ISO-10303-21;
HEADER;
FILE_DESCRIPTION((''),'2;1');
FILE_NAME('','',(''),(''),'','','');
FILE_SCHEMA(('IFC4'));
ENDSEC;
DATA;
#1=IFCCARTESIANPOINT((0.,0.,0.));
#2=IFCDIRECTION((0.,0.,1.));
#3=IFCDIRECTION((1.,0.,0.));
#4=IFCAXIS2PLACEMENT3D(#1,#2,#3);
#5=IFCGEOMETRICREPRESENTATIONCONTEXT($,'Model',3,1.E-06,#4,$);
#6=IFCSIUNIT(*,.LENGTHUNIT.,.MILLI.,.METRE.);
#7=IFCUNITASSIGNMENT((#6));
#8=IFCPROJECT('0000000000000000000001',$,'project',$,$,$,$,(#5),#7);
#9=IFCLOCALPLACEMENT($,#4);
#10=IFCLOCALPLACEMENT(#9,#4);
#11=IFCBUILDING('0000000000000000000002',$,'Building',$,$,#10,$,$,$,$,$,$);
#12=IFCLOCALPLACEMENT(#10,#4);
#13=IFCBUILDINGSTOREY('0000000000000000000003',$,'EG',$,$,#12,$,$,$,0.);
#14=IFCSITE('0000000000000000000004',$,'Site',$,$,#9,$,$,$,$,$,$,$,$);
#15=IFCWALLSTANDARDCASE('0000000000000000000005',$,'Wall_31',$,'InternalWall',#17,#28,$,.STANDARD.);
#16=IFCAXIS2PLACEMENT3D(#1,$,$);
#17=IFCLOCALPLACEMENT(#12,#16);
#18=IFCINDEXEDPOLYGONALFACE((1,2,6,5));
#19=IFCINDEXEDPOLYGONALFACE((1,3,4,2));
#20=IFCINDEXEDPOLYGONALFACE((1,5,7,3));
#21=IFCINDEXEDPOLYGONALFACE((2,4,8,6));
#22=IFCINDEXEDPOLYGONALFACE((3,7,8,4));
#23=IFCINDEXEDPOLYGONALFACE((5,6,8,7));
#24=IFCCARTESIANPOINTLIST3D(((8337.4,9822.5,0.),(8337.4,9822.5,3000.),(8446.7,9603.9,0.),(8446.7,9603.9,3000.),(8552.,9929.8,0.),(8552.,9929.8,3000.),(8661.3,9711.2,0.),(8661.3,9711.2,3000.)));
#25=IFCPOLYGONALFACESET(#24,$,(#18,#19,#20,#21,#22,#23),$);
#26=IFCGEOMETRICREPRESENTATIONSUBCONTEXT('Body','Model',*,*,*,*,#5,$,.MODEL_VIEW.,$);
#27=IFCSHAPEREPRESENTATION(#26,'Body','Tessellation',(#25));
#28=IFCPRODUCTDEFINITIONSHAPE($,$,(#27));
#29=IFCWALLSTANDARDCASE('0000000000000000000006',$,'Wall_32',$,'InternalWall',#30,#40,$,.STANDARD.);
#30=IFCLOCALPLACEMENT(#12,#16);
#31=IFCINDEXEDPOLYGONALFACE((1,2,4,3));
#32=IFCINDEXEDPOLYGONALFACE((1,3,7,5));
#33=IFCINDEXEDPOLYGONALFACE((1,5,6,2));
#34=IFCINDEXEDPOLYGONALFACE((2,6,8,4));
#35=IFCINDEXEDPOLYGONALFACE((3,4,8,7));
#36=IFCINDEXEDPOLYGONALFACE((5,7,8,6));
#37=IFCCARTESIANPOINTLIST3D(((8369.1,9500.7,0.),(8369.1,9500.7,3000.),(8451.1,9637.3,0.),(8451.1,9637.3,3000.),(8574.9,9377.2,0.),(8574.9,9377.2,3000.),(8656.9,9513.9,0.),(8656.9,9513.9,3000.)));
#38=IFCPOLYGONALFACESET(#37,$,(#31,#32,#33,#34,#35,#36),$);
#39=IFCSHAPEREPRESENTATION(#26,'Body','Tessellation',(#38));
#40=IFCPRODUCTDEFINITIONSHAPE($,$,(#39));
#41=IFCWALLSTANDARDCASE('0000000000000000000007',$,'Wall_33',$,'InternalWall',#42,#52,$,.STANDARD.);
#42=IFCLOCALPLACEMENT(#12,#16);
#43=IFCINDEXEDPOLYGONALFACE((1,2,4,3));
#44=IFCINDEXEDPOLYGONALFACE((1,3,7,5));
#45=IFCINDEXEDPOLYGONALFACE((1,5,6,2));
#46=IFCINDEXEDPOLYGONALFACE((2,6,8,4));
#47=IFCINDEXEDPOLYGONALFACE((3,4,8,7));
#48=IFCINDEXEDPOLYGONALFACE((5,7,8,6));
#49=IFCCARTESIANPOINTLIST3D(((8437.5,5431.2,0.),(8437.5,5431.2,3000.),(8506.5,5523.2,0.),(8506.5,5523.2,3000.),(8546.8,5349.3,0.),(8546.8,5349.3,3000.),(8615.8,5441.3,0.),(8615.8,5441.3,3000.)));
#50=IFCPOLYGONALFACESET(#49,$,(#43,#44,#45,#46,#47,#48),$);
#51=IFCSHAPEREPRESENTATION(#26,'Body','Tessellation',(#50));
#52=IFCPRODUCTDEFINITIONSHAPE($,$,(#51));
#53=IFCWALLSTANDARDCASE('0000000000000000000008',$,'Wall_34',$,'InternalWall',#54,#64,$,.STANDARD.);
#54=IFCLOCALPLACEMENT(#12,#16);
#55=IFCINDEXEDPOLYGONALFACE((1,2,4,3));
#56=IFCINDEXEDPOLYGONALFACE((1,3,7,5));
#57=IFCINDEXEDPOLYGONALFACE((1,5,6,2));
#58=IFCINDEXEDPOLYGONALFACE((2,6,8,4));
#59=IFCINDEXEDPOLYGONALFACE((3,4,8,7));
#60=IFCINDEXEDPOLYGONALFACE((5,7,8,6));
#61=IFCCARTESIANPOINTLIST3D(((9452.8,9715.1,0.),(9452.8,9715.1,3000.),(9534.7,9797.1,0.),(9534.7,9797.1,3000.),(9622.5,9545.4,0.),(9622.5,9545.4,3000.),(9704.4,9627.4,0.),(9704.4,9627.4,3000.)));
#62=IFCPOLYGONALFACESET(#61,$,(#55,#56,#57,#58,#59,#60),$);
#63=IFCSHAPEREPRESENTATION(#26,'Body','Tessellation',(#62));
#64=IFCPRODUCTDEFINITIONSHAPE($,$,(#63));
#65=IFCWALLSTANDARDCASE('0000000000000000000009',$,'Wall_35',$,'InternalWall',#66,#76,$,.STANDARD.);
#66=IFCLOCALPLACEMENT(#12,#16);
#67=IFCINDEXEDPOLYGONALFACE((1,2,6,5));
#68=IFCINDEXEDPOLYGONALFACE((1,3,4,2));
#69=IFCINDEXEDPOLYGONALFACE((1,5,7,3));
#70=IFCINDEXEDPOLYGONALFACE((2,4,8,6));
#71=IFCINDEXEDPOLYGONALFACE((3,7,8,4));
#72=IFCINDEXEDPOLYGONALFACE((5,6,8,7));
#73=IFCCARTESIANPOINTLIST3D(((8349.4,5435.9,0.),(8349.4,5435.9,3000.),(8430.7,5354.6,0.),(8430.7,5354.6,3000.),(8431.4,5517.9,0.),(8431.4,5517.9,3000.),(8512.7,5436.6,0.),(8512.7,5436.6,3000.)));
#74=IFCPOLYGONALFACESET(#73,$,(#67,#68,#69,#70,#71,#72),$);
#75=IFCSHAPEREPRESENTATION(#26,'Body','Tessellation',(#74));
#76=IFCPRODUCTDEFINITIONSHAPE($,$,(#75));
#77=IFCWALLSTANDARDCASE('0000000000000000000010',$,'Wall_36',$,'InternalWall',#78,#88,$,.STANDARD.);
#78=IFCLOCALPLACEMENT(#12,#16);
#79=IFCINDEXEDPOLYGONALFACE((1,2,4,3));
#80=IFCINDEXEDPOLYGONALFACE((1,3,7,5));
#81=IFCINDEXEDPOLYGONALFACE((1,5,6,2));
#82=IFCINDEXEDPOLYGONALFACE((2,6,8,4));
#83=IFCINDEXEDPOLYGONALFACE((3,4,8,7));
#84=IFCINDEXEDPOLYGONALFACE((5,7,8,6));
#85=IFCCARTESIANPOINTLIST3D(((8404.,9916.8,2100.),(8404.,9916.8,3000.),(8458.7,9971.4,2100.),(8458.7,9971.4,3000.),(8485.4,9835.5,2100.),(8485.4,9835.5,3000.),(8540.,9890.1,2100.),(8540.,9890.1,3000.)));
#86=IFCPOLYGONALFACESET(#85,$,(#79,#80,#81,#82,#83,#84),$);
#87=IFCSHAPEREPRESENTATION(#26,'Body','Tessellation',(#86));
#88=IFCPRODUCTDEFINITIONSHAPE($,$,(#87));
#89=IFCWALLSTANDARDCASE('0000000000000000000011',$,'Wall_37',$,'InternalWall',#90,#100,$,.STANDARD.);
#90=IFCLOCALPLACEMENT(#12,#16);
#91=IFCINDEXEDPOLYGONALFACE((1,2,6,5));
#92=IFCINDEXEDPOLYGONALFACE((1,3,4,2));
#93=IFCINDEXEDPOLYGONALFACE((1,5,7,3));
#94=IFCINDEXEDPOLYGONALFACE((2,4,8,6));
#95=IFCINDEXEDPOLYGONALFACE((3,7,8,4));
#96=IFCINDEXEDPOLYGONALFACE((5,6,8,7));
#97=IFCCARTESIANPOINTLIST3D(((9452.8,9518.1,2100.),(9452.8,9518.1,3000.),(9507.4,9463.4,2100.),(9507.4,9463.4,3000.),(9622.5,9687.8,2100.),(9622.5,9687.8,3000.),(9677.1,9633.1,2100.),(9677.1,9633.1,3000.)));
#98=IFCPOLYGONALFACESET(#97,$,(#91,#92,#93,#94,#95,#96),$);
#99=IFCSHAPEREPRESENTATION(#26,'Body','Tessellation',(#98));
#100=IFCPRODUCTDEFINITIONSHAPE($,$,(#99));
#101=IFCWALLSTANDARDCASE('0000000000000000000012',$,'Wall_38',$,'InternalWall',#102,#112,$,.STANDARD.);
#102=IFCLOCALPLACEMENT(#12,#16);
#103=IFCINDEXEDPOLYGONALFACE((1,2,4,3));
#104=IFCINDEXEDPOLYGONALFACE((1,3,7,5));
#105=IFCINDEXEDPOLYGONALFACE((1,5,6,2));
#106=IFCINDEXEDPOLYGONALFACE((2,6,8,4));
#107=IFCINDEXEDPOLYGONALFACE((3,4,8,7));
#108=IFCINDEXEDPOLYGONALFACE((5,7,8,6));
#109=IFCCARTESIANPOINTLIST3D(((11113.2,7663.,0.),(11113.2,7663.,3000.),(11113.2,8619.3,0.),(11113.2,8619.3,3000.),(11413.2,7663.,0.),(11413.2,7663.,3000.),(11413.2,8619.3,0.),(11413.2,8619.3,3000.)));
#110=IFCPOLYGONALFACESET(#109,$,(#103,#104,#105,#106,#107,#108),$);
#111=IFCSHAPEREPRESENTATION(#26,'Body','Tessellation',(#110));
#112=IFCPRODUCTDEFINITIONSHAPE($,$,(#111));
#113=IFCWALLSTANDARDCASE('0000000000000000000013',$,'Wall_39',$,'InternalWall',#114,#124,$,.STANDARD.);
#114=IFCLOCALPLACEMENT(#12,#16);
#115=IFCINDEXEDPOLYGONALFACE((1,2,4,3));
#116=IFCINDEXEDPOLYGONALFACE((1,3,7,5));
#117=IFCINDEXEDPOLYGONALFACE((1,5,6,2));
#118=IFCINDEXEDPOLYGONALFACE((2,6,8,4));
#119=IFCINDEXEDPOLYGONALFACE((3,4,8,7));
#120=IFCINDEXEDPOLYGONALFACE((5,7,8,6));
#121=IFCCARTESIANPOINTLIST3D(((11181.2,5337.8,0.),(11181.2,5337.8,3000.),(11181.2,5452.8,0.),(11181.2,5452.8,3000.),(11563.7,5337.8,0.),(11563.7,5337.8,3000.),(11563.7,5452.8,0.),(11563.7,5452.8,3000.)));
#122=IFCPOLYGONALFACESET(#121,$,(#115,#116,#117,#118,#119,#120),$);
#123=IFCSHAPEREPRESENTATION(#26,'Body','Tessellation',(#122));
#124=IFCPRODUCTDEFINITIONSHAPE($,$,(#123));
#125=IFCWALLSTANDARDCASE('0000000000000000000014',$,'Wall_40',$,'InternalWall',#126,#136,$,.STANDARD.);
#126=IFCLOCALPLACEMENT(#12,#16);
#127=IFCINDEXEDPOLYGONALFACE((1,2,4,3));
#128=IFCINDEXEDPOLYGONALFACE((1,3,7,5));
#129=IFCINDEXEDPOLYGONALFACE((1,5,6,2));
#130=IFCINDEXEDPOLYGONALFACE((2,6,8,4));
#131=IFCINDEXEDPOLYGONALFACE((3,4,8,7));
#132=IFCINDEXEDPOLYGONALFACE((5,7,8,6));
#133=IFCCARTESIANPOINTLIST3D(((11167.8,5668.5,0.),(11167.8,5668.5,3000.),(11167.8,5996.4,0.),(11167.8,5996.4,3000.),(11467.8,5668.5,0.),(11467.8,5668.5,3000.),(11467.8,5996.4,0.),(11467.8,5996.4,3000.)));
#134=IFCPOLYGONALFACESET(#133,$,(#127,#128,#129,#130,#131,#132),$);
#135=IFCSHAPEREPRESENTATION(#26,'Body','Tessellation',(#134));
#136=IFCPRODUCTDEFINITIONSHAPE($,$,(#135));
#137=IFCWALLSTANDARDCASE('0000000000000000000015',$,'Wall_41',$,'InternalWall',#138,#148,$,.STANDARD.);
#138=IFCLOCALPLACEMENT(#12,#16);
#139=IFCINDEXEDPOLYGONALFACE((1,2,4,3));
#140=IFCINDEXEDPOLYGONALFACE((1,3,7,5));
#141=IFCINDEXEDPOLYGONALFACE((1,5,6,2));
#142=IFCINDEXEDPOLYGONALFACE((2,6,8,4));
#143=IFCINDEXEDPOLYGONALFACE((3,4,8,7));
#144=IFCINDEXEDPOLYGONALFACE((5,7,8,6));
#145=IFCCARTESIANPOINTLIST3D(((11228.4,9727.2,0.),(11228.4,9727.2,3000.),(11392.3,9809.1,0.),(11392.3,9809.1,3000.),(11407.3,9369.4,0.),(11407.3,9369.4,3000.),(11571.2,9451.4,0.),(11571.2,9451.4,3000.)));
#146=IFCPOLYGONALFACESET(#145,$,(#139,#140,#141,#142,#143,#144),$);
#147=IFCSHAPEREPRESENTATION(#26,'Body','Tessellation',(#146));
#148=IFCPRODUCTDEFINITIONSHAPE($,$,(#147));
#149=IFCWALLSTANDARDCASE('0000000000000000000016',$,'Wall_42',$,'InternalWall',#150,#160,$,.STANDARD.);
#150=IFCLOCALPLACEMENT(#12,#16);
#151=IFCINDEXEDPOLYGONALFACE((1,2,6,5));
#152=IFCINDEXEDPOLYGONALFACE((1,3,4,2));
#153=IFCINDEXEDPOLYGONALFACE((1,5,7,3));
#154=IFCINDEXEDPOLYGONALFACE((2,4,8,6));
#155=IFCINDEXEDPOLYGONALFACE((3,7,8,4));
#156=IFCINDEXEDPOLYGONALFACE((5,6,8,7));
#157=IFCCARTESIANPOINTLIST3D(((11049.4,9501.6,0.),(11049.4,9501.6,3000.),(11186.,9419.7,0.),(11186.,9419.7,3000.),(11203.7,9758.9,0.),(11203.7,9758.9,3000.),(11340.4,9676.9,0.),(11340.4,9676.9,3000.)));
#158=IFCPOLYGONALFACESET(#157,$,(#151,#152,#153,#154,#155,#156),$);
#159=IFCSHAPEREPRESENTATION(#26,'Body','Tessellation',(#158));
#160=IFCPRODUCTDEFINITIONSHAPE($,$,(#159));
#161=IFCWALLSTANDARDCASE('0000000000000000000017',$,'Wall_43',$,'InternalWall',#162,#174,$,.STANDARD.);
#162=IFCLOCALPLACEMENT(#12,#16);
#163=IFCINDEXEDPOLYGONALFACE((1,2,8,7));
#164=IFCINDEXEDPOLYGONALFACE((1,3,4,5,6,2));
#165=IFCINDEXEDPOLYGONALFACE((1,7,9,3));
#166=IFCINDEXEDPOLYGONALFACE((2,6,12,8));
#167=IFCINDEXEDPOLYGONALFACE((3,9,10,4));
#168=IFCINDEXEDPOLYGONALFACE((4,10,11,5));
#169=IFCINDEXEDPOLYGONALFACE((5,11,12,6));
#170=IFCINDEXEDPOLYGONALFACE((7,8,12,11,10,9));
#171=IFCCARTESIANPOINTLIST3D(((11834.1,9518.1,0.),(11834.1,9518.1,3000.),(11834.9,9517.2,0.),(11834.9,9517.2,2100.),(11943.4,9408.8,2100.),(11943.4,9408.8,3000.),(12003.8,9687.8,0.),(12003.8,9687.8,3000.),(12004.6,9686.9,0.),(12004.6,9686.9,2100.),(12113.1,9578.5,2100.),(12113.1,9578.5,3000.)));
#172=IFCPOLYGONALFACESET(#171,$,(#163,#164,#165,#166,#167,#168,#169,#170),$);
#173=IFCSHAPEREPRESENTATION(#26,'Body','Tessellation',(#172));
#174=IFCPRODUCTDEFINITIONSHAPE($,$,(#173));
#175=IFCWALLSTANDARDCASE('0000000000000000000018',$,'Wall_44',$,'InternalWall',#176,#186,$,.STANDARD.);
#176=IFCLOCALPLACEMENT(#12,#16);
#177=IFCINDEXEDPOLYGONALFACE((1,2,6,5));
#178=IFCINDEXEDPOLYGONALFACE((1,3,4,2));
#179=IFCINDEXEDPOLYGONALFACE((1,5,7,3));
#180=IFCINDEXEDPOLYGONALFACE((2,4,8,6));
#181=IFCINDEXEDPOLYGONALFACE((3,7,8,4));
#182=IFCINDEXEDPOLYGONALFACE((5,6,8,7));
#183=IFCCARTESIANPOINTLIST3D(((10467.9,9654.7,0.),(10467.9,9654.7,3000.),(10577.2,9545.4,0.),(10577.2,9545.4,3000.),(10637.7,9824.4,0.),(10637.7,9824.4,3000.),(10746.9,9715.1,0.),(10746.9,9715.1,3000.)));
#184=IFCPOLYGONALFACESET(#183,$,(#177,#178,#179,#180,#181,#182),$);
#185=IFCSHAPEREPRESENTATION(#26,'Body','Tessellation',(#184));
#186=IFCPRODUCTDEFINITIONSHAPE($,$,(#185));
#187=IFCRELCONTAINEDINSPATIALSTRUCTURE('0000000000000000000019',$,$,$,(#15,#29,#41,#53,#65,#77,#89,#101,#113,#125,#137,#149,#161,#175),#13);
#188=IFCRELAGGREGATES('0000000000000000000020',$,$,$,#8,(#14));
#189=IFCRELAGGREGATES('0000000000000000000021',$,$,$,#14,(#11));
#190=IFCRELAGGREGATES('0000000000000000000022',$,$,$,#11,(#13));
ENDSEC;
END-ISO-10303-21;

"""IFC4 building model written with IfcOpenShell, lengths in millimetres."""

from ifc_helpers import new_model, si_unit, frame, origin_with_axes, place, context, subcontext, project, spatial, rectangle, extrude, element, save


model = new_model("IFC4")

# Units and contexts
model_context = context("Model", 3, precision=1e-06, world=origin_with_axes())
body_context = subcontext(model_context, "Body", "Model", "MODEL_VIEW")
ifc_project = project(units=[si_unit("LENGTHUNIT", "METRE", prefix="MILLI")], contexts=[model_context])

# Site, building, storey
site_placement = place(None, origin_with_axes())
site = spatial("IfcSite", under=ifc_project, at=site_placement, Name="Site")
building_placement = place(site_placement, origin_with_axes())
building = spatial("IfcBuilding", under=site, at=building_placement, Name="Building")
storey_placement = place(building_placement, origin_with_axes())
storey = spatial("IfcBuildingStorey", under=building, at=storey_placement, Name="EG", Elevation=0.0)

# Walls
wall_1_placement = place(storey_placement, origin_with_axes())
element("IfcWallStandardCase", 1, at=wall_1_placement, inside=storey, Name="Wall_31", ObjectType="InternalWall", PredefinedType="STANDARD", context=body_context, shape_type="SweptSolid", body=[
    extrude(rectangle(XDim=244.4, YDim=240.0), frame((8499.4, 9766.9, 0.0), z_axis=(0.0, 0.0, 1.0), x_axis=(-0.447214, 0.894427, 0.0)), (0.0, 0.0, 1.0), 3000.0),
])
wall_2_placement = place(storey_placement, origin_with_axes())
element("IfcWallStandardCase", 2, at=wall_2_placement, inside=storey, Name="Wall_32", ObjectType="InternalWall", PredefinedType="STANDARD", context=body_context, shape_type="SweptSolid", body=[
    extrude(rectangle(XDim=159.3, YDim=240.0), frame((8513.0, 9507.3, 0.0), z_axis=(0.0, 0.0, 1.0), x_axis=(0.514496, 0.857493, 0.0)), (0.0, 0.0, 1.0), 3000.0),
])
wall_3_placement = place(storey_placement, origin_with_axes())
element("IfcWallStandardCase", 3, at=wall_3_placement, inside=storey, Name="Wall_33", ObjectType="InternalWall", PredefinedType="STANDARD", context=body_context, shape_type="SweptSolid", body=[
    extrude(rectangle(XDim=136.6, YDim=115.0), frame((8526.7, 5436.3, 0.0), z_axis=(0.0, 0.0, 1.0), x_axis=(0.8, -0.6, 0.0)), (0.0, 0.0, 1.0), 3000.0),
])
wall_4_placement = place(storey_placement, origin_with_axes())
element("IfcWallStandardCase", 4, at=wall_4_placement, inside=storey, Name="Wall_34", ObjectType="InternalWall", PredefinedType="STANDARD", context=body_context, shape_type="SweptSolid", body=[
    extrude(rectangle(XDim=115.9, YDim=240.0), frame((9578.6, 9671.2, 0.0), z_axis=(0.0, 0.0, 1.0), x_axis=(0.707107, 0.707107, 0.0)), (0.0, 0.0, 1.0), 3000.0),
])
wall_5_placement = place(storey_placement, origin_with_axes())
element("IfcWallStandardCase", 5, at=wall_5_placement, inside=storey, Name="Wall_35", ObjectType="InternalWall", PredefinedType="STANDARD", context=body_context, shape_type="SweptSolid", body=[
    extrude(rectangle(XDim=115.9, YDim=115.0), frame((8431.0, 5436.3, 0.0), z_axis=(0.0, 0.0, 1.0), x_axis=(-0.707107, -0.707107, 0.0)), (0.0, 0.0, 1.0), 3000.0),
])

# Walls, openings
wall_6_placement = place(storey_placement, origin_with_axes())
wall_6 = element("IfcWallStandardCase", 6, at=wall_6_placement, inside=storey, Name="Wall_36", ObjectType="InternalWall", PredefinedType="STANDARD", context=body_context, shape_type="SweptSolid", body=[
    extrude(rectangle(XDim=77.3, YDim=115.0), frame((8472.0, 9903.5, 0.0), z_axis=(0.0, 0.0, 1.0), x_axis=(0.707107, 0.707107, 0.0)), (0.0, 0.0, 1.0), 3000.0),
])
opening_1_placement = place(wall_6_placement, origin_with_axes())
element("IfcOpeningElement", 7, at=opening_1_placement, inside=storey, cuts=wall_6, context=body_context, shape_type="SweptSolid", body=[
    extrude(rectangle(XDim=1086.4, YDim=115.0), frame((8639.8, 10071.2, 0.0), z_axis=(0.0, 0.0, 1.0), x_axis=(0.707107, 0.707107, 0.0)), (0.0, 0.0, 1.0), 2100.0),
])
wall_7_placement = place(storey_placement, origin_with_axes())
wall_7 = element("IfcWallStandardCase", 8, at=wall_7_placement, inside=storey, Name="Wall_37", ObjectType="InternalWall", PredefinedType="STANDARD", context=body_context, shape_type="SweptSolid", body=[
    extrude(rectangle(XDim=77.3, YDim=240.0), frame((9564.9, 9575.6, 0.0), z_axis=(0.0, 0.0, 1.0), x_axis=(0.707107, -0.707107, 0.0)), (0.0, 0.0, 1.0), 3000.0),
])
opening_2_placement = place(wall_7_placement, origin_with_axes())
element("IfcOpeningElement", 9, at=opening_2_placement, inside=storey, cuts=wall_7, context=body_context, shape_type="SweptSolid", body=[
    extrude(rectangle(XDim=1325.8, YDim=240.0), frame((9986.9, 9153.6, 0.0), z_axis=(0.0, 0.0, 1.0), x_axis=(0.707107, -0.707107, 0.0)), (0.0, 0.0, 1.0), 2100.0),
])

# Walls
wall_8_placement = place(storey_placement, origin_with_axes())
element("IfcWallStandardCase", 10, at=wall_8_placement, inside=storey, Name="Wall_38", ObjectType="InternalWall", PredefinedType="STANDARD", context=body_context, shape_type="SweptSolid", body=[
    extrude(rectangle(XDim=956.3, YDim=300.0), frame((11263.2, 8141.2, 0.0), z_axis=(0.0, 0.0, 1.0), x_axis=(0.0, 1.0, 0.0)), (0.0, 0.0, 1.0), 3000.0),
])
wall_9_placement = place(storey_placement, origin_with_axes())
element("IfcWallStandardCase", 11, at=wall_9_placement, inside=storey, Name="Wall_39", ObjectType="InternalWall", PredefinedType="STANDARD", context=body_context, shape_type="SweptSolid", body=[
    extrude(rectangle(XDim=382.5, YDim=115.0), frame((11372.5, 5395.3, 0.0), z_axis=(0.0, 0.0, 1.0), x_axis=(1.0, 0.0, 0.0)), (0.0, 0.0, 1.0), 3000.0),
])
wall_10_placement = place(storey_placement, origin_with_axes())
element("IfcWallStandardCase", 12, at=wall_10_placement, inside=storey, Name="Wall_40", ObjectType="InternalWall", PredefinedType="STANDARD", context=body_context, shape_type="SweptSolid", body=[
    extrude(rectangle(XDim=327.9, YDim=300.0), frame((11317.8, 5832.4, 0.0), z_axis=(0.0, 0.0, 1.0), x_axis=(0.0, -1.0, 0.0)), (0.0, 0.0, 1.0), 3000.0),
])
wall_11_placement = place(storey_placement, origin_with_axes())
element("IfcWallStandardCase", 13, at=wall_11_placement, inside=storey, Name="Wall_41", ObjectType="InternalWall", PredefinedType="STANDARD", context=body_context, shape_type="SweptSolid", body=[
    extrude(rectangle(XDim=183.3, YDim=400.0), frame((11399.8, 9589.3, 0.0), z_axis=(0.0, 0.0, 1.0), x_axis=(0.894427, 0.447214, 0.0)), (0.0, 0.0, 1.0), 3000.0),
])
wall_12_placement = place(storey_placement, origin_with_axes())
element("IfcWallStandardCase", 14, at=wall_12_placement, inside=storey, Name="Wall_42", ObjectType="InternalWall", PredefinedType="STANDARD", context=body_context, shape_type="SweptSolid", body=[
    extrude(rectangle(XDim=159.3, YDim=300.0), frame((11194.9, 9589.3, 0.0), z_axis=(0.0, 0.0, 1.0), x_axis=(0.857493, -0.514496, 0.0)), (0.0, 0.0, 1.0), 3000.0),
])

# Wall, opening
wall_13_placement = place(storey_placement, origin_with_axes())
wall_13 = element("IfcWallStandardCase", 15, at=wall_13_placement, inside=storey, Name="Wall_43", ObjectType="InternalWall", PredefinedType="STANDARD", context=body_context, shape_type="SweptSolid", body=[
    extrude(rectangle(XDim=154.6, YDim=240.0), frame((11973.6, 9548.3, 0.0), z_axis=(0.0, 0.0, 1.0), x_axis=(0.707107, -0.707107, 0.0)), (0.0, 0.0, 1.0), 3000.0),
])
opening_3_placement = place(wall_13_placement, origin_with_axes())
element("IfcOpeningElement", 16, at=opening_3_placement, inside=storey, cuts=wall_13, context=body_context, shape_type="SweptSolid", body=[
    extrude(rectangle(XDim=1289.0, YDim=240.0), frame((12375.5, 9146.3, 0.0), z_axis=(0.0, 0.0, 1.0), x_axis=(0.707107, -0.707107, 0.0)), (0.0, 0.0, 1.0), 2100.0),
])

# Wall
wall_14_placement = place(storey_placement, origin_with_axes())
element("IfcWallStandardCase", 17, at=wall_14_placement, inside=storey, Name="Wall_44", ObjectType="InternalWall", PredefinedType="STANDARD", context=body_context, shape_type="SweptSolid", body=[
    extrude(rectangle(XDim=154.6, YDim=240.0), frame((10607.4, 9684.9, 0.0), z_axis=(0.0, 0.0, 1.0), x_axis=(-0.707107, 0.707107, 0.0)), (0.0, 0.0, 1.0), 3000.0),
])

save(model, "model.ifc")
